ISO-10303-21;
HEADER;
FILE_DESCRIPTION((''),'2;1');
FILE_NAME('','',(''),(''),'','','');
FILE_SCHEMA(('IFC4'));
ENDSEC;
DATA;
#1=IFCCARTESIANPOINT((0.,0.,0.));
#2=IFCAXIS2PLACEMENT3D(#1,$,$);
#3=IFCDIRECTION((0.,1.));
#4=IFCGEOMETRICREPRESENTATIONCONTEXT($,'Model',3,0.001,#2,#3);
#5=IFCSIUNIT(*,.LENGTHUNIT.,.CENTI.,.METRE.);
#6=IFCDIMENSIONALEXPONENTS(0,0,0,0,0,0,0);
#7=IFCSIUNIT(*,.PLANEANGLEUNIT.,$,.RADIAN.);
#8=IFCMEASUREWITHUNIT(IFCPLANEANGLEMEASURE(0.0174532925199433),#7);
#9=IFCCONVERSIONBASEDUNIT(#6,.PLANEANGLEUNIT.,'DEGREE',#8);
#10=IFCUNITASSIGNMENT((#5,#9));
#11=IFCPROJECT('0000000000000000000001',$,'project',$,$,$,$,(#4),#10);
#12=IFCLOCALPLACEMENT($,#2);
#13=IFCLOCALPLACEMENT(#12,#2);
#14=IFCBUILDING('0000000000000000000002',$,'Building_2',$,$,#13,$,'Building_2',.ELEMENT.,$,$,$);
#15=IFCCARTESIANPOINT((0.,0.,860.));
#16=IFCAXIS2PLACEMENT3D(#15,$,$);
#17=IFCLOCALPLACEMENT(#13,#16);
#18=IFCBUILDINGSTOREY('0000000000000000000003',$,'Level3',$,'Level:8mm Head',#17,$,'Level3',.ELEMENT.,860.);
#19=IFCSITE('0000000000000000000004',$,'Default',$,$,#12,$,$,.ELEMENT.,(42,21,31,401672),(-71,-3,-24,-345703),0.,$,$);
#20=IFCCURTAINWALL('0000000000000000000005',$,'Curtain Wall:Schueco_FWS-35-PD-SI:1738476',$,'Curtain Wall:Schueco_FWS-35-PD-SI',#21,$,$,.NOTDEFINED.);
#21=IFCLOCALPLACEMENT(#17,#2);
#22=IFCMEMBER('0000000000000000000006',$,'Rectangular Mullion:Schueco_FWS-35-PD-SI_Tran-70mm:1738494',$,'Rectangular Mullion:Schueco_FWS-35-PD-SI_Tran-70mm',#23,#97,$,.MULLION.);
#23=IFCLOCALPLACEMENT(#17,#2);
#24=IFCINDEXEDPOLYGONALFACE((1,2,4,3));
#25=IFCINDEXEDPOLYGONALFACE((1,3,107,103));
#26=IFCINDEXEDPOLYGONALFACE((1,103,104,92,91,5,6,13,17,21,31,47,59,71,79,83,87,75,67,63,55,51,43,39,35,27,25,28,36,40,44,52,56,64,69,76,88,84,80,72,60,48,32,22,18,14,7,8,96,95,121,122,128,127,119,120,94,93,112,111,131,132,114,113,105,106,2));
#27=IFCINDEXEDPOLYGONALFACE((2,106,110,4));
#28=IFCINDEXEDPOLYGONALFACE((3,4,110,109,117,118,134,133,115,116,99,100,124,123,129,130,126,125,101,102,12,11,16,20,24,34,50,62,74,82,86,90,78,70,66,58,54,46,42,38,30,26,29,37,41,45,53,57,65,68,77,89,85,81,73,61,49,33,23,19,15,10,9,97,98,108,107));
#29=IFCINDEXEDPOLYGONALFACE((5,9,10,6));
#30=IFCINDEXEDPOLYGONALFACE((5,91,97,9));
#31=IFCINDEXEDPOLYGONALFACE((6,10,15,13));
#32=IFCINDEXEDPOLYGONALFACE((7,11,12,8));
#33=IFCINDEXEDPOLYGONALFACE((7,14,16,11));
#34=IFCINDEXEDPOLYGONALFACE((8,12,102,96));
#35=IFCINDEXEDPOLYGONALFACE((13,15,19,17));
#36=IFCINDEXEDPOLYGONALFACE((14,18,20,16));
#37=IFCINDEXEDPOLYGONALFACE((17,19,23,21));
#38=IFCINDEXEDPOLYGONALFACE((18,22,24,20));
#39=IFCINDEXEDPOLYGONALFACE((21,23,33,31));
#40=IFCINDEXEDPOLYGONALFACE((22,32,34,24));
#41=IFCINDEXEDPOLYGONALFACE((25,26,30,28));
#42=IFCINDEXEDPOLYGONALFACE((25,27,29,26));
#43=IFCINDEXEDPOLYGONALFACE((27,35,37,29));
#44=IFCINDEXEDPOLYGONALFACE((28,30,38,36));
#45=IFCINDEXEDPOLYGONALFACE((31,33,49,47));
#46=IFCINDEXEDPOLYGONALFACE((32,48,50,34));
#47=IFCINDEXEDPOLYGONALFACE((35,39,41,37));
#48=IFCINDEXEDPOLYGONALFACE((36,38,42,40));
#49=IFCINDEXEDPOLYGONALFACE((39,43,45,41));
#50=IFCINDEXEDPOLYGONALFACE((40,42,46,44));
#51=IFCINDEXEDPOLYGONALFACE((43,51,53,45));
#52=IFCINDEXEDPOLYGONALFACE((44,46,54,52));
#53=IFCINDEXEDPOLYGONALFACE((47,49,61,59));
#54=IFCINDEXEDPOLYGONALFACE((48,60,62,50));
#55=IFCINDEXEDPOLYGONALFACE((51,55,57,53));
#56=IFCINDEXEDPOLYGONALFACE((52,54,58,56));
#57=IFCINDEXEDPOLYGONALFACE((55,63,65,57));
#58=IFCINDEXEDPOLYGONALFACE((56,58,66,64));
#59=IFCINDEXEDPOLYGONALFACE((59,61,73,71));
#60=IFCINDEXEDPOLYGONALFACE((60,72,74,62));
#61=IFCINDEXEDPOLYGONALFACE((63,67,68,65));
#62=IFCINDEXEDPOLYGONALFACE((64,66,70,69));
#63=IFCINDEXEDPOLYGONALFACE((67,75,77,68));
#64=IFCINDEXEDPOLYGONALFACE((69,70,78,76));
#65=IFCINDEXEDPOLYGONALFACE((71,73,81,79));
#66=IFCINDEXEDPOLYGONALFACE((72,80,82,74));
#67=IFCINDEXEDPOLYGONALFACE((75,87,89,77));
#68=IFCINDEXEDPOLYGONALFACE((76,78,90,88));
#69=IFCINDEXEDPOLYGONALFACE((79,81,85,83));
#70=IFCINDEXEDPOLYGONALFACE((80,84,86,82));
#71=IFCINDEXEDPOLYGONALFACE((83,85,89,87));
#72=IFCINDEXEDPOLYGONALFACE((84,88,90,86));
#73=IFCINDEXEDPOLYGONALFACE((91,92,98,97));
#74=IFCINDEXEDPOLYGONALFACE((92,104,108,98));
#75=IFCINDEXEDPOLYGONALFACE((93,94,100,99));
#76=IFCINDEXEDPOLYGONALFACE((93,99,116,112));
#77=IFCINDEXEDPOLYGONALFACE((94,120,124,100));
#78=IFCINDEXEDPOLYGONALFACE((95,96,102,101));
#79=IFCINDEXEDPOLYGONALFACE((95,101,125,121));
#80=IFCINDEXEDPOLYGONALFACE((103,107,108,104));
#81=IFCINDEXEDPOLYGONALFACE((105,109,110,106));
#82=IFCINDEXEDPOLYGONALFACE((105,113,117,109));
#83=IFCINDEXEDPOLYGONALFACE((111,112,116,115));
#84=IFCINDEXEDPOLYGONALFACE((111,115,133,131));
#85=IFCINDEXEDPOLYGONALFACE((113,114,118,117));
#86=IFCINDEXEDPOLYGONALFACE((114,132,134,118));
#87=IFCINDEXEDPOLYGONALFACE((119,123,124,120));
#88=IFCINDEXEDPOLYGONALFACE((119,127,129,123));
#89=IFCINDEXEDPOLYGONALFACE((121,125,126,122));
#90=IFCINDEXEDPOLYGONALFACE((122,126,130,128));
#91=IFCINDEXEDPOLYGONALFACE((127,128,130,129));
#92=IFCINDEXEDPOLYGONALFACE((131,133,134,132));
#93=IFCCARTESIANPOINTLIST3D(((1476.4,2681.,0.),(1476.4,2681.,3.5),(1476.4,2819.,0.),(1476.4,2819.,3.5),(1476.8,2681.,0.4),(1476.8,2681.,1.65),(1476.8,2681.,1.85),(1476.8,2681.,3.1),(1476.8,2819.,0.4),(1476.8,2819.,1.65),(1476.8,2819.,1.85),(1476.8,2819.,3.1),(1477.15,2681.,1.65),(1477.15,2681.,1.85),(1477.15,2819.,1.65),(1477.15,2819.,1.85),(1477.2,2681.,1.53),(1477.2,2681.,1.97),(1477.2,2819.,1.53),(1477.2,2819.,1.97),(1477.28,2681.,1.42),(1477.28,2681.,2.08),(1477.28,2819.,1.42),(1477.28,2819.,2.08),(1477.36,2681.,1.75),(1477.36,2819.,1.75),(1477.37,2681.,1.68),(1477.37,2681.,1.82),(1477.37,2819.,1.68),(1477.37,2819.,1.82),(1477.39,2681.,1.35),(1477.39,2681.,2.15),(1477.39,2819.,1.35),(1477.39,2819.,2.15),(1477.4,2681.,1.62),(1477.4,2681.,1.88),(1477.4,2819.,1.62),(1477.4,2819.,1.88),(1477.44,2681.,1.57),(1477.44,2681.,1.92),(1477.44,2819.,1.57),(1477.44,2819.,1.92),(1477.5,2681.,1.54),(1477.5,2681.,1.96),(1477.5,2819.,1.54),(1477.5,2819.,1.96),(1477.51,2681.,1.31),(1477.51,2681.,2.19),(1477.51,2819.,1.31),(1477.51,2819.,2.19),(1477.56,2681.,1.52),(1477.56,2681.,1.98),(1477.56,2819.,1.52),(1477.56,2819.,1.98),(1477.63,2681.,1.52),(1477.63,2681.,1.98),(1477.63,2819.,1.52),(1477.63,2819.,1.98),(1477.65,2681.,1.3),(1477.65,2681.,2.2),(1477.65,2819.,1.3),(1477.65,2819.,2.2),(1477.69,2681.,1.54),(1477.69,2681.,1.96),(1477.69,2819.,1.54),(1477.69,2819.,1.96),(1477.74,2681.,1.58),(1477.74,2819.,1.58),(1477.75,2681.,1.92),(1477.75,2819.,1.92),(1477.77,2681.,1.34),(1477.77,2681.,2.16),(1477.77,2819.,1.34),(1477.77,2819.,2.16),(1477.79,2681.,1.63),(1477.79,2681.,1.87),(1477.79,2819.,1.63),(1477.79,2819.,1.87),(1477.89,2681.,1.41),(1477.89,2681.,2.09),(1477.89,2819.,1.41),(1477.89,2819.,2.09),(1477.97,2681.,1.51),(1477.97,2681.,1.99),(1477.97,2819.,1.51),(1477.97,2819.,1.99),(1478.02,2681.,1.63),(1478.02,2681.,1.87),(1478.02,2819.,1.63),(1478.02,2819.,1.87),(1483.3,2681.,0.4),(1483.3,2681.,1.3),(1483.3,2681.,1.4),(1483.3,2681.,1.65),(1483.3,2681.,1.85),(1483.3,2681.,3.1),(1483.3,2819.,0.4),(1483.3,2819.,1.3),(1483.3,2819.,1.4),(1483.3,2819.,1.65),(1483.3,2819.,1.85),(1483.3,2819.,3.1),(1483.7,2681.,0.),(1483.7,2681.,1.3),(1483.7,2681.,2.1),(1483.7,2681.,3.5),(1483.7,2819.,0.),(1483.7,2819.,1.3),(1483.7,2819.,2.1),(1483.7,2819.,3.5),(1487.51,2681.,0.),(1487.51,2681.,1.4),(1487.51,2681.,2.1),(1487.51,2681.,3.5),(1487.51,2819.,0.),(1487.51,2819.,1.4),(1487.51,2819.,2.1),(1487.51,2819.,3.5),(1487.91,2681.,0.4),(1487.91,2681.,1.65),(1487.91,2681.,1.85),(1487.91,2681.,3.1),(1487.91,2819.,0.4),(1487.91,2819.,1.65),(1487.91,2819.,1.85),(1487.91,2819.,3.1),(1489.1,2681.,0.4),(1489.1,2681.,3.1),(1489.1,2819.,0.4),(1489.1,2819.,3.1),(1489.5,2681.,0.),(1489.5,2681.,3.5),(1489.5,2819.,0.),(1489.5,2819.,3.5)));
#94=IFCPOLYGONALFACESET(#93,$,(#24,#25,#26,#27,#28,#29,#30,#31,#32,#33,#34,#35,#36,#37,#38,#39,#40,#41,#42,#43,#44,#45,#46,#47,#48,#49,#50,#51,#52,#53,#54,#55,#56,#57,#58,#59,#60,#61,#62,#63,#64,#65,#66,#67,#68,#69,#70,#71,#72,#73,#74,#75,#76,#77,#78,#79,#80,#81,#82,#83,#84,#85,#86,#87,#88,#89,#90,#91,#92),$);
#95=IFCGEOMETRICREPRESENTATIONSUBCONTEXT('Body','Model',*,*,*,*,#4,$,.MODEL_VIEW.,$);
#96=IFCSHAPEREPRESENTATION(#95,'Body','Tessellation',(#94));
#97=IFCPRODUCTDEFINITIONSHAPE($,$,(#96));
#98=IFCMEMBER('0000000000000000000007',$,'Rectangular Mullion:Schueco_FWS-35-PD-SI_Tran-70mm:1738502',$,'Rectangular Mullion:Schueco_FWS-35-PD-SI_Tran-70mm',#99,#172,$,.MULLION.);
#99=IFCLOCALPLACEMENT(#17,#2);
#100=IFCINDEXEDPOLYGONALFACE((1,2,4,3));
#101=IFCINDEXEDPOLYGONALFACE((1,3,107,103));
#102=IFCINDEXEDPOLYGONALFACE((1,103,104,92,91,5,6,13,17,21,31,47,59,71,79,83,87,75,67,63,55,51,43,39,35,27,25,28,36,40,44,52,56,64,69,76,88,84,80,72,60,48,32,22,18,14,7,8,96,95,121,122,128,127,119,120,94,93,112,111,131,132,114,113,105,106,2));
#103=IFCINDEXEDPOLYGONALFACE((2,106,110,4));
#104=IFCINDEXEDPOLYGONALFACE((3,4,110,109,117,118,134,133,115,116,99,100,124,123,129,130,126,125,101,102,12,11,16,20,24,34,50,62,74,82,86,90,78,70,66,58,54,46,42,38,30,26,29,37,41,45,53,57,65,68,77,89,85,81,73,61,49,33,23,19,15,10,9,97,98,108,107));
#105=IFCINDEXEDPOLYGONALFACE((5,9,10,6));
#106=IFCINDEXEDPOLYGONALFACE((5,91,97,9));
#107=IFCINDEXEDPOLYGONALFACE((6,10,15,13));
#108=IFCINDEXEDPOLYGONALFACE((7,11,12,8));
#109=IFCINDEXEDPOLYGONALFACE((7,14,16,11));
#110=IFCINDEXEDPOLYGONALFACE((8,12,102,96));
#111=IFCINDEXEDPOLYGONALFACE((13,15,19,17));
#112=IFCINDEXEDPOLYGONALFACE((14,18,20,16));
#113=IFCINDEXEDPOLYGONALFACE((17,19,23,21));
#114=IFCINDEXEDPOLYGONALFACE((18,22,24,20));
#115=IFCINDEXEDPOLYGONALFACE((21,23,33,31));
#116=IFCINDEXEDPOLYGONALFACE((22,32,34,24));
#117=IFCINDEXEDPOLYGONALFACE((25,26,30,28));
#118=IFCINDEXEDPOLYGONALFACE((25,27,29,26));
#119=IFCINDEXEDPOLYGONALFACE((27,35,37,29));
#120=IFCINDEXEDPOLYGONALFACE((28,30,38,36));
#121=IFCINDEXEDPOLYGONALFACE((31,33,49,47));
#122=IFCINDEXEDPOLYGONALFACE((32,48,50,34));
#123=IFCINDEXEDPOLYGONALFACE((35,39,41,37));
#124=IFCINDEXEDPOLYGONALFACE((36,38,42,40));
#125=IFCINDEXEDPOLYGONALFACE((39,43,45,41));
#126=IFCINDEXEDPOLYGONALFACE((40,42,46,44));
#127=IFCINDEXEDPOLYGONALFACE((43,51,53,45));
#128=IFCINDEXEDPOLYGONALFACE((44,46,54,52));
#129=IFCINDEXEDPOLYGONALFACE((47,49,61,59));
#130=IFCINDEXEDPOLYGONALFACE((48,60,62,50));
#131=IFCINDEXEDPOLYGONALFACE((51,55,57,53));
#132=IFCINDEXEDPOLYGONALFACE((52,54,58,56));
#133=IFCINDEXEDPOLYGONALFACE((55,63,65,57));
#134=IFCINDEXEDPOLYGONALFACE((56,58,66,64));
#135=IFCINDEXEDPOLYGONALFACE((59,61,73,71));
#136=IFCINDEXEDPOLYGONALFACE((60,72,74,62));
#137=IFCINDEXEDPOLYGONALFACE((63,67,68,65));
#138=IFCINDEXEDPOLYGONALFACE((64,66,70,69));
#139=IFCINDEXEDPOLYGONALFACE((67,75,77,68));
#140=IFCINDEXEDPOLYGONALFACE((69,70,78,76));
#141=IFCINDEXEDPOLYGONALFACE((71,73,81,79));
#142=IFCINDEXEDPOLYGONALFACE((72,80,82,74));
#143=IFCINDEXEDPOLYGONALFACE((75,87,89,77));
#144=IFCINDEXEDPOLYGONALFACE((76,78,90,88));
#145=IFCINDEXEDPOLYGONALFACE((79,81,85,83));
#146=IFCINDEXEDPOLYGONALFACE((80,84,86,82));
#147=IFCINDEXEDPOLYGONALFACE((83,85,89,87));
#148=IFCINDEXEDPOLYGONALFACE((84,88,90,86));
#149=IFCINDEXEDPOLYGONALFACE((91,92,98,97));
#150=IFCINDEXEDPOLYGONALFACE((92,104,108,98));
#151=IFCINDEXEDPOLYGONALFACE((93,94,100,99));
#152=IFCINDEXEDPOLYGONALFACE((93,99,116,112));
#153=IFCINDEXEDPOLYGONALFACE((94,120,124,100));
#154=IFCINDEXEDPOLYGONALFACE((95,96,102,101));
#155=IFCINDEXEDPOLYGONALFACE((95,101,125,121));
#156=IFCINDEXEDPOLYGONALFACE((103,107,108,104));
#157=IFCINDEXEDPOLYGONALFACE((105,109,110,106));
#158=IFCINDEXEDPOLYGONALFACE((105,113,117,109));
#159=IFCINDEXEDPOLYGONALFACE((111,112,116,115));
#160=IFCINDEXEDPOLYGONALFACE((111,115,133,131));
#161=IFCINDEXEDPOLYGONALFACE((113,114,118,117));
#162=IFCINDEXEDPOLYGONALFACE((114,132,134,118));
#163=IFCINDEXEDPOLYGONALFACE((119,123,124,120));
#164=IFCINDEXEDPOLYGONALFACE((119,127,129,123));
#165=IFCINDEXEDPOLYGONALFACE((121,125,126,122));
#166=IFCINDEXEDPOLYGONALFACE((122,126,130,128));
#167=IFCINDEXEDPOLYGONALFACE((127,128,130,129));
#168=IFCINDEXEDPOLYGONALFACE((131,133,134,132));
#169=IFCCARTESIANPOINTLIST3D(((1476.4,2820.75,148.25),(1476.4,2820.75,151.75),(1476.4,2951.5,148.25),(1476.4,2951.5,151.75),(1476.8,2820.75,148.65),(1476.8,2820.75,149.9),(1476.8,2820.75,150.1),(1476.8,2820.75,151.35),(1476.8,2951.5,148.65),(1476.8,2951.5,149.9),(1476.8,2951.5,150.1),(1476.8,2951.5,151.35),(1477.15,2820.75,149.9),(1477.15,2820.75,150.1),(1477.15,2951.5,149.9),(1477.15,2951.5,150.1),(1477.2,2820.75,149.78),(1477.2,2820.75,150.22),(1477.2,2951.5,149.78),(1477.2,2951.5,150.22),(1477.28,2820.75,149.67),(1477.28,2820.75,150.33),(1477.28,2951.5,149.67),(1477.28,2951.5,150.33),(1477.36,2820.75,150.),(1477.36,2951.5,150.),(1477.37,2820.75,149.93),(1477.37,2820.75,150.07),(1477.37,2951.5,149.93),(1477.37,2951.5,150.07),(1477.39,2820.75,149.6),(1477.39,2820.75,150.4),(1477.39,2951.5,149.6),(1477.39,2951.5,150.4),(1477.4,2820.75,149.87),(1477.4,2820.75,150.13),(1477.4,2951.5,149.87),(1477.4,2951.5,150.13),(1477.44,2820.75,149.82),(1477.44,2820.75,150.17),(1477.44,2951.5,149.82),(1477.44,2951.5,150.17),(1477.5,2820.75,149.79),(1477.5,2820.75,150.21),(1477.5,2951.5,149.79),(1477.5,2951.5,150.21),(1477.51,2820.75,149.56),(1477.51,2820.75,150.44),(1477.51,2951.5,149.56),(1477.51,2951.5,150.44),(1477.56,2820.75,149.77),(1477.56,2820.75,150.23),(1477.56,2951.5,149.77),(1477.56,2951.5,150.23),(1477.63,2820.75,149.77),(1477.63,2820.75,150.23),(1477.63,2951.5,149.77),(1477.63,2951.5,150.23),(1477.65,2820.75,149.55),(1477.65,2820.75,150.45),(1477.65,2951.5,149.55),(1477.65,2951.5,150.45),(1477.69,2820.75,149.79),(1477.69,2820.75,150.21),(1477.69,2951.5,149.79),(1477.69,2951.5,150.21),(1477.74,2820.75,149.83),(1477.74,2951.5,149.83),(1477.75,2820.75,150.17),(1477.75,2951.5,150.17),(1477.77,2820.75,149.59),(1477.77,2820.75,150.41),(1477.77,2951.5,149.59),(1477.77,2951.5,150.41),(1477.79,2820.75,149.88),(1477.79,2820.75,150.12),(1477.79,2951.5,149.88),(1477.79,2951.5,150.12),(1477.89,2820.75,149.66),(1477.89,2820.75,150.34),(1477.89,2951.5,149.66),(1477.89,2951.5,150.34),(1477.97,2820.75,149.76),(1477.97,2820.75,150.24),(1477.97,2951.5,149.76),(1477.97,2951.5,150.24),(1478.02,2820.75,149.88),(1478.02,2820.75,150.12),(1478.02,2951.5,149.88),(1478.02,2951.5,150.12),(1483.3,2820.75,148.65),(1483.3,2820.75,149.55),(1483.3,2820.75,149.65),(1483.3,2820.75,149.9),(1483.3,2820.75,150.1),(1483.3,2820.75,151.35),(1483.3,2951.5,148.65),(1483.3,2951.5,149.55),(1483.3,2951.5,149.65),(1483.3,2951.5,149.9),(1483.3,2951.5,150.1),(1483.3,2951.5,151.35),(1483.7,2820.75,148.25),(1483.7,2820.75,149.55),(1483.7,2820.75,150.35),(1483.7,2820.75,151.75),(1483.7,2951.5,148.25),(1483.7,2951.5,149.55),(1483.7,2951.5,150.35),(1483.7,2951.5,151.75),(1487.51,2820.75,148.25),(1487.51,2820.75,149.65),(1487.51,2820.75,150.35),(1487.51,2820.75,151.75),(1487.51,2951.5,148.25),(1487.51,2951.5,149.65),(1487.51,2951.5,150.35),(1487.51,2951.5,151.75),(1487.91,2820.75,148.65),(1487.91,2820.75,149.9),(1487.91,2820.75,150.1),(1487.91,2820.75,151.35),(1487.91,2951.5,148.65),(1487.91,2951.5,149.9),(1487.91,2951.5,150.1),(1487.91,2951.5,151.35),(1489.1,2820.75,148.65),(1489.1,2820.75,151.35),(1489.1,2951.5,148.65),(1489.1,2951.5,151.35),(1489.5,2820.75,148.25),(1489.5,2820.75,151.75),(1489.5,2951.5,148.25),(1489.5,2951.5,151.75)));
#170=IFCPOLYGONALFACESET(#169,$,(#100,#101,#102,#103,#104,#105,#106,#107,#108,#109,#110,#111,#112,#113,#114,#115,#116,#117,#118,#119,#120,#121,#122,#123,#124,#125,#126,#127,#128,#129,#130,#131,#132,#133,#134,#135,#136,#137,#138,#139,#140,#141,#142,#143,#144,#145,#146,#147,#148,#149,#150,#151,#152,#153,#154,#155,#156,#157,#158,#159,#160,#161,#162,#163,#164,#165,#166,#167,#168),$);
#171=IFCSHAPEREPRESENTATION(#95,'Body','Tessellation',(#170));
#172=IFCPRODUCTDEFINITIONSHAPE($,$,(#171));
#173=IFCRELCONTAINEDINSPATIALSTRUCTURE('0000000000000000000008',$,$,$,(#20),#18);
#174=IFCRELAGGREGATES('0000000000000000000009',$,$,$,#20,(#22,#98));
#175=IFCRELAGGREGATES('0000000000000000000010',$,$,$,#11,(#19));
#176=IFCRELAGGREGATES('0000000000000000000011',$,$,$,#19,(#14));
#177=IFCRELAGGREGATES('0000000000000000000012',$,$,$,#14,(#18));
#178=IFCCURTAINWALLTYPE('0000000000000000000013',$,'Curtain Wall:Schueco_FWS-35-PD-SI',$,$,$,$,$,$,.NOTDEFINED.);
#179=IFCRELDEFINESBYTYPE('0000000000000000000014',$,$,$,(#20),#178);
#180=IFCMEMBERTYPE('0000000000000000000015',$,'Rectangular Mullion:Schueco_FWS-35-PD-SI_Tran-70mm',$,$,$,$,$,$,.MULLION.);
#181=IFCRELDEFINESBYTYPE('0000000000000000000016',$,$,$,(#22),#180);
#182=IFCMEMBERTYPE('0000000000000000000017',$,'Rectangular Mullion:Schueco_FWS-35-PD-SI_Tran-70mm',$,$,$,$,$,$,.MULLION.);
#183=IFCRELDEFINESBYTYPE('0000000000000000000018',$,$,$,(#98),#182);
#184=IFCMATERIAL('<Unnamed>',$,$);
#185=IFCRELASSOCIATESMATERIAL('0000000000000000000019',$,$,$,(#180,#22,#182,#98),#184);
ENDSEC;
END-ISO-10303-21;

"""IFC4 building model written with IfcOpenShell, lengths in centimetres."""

from ifc_helpers import new_model, entity, si_unit, converted_unit, direction, frame, origin, place, context, subcontext, project, spatial, line, arc, indexed_curve, outline, extrude, source, transform, mapped, material, type_object, type_shapes, element, aggregate, save


model = new_model("IFC4")

# Units and contexts
model_context = context("Model", 3, precision=0.001, world=origin(), true_north=direction((0.0, 1.0)))
body_context = subcontext(model_context, "Body", "Model", "MODEL_VIEW")
ifc_project = project(units=[si_unit("LENGTHUNIT", "METRE", prefix="CENTI"), converted_unit("PLANEANGLEUNIT", "DEGREE", entity("IfcPlaneAngleMeasure", 0.0174532925199433), si_unit("PLANEANGLEUNIT", "RADIAN"), dimensions=[0, 0, 0, 0, 0, 0, 0])], contexts=[model_context])

# Site, building, storey
site_placement = place(None, origin())
site = spatial("IfcSite", under=ifc_project, at=site_placement, Name="Default", CompositionType="ELEMENT", RefLatitude=(42, 21, 31, 401672), RefLongitude=(-71, -3, -24, -345703), RefElevation=0.0)
building_placement = place(site_placement, origin())
building = spatial("IfcBuilding", under=site, at=building_placement, Name="Building_2", LongName="Building_2", CompositionType="ELEMENT")
storey_placement = place(building_placement, frame((0.0, 0.0, 860.0)))
storey = spatial("IfcBuildingStorey", under=building, at=storey_placement, Name="Level3", ObjectType="Level:8mm Head", LongName="Level3", CompositionType="ELEMENT", Elevation=860.0)

# Curtain wall, members
curtain_wall_type = type_object("IfcCurtainWallType", Name="Curtain Wall:Schueco_FWS-35-PD-SI", PredefinedType="NOTDEFINED")
curtain_wall_placement = place(storey_placement, frame((0.0, 0.0, -860.0)))
curtain_wall = element("IfcCurtainWall", 1, at=curtain_wall_placement, inside=storey, type_object=curtain_wall_type, Name="Curtain Wall:Schueco_FWS-35-PD-SI:1738476", ObjectType="Curtain Wall:Schueco_FWS-35-PD-SI", PredefinedType="NOTDEFINED")
ifc_material_1 = material(Name="<Unnamed>")
member_type_1 = type_object("IfcMemberType", Name="Rectangular Mullion:Schueco_FWS-35-PD-SI_Tran-70mm", PredefinedType="MULLION", material=ifc_material_1)
shared_shape_1 = source(origin(), body_context, "Body", "SweptSolid", [
    extrude(outline(indexed_curve([(-6.52, -1.78), (0.78, -1.78), (0.78, -0.38), (4.59, -0.38), (4.59, -1.78), (6.58, -1.78), (6.58, 1.72), (4.59, 1.72), (4.59, 0.32), (0.38, 0.32), (0.38, 0.07), (4.99, 0.07), (4.99, 1.32), (6.18, 1.32), (6.18, -1.38), (4.99, -1.38), (4.99, -0.13), (0.38, -0.13), (0.38, -1.38), (-6.12, -1.38), (-6.12, -0.13), (-5.77, -0.13), (-5.34, -0.48), (-4.9, -0.15), (-5.14, -0.15), (-5.56, -0.03), (-5.14, 0.09), (-4.9, 0.09), (-5.34, 0.42), (-5.77, 0.07), (-6.12, 0.07), (-6.12, 1.32), (0.38, 1.32), (0.38, 0.42), (0.78, 0.42), (0.78, 1.72), (-6.52, 1.72)], segments=[line(1, 2, 3, 4, 5, 6, 7, 8, 9, 10, 11, 12, 13, 14, 15, 16, 17, 18, 19, 20, 21, 22), arc(22, 23, 24), line(24, 25), arc(25, 26, 27), line(27, 28), arc(28, 29, 30), line(30, 31, 32, 33, 34, 35, 36, 37, 1)], self_intersect=False)), frame((-1.72, 4.58, -138.0), z_axis=(0.0, 0.0, 1.0), x_axis=(0.0, -1.0, 0.0)), (0.0, 0.0, 1.0), 138.0),
])
type_shapes(member_type_1, [shared_shape_1])
member_1_placement = place(curtain_wall_placement, frame((1487.5, 2819.0, 860.0), z_axis=(0.0, 1.0, 0.0), x_axis=(0.0, 0.0, -1.0)))
member_1 = element("IfcMember", 2, at=member_1_placement, type_object=member_type_1, material=ifc_material_1, Name="Rectangular Mullion:Schueco_FWS-35-PD-SI_Tran-70mm:1738494", ObjectType="Rectangular Mullion:Schueco_FWS-35-PD-SI_Tran-70mm", PredefinedType="MULLION", context=body_context, shape_type="MappedRepresentation", body=[
    mapped(shared_shape_1, transform((0.0, 0.0, 0.0), scale=1.0)),
])
member_type_2 = type_object("IfcMemberType", Name="Rectangular Mullion:Schueco_FWS-35-PD-SI_Tran-70mm", PredefinedType="MULLION", material=ifc_material_1)
shared_shape_2 = source(origin(), body_context, "Body", "SweptSolid", [
    extrude(outline(indexed_curve([(-1.78, -6.52), (1.72, -6.52), (1.72, 0.78), (0.42, 0.78), (0.42, 0.38), (1.32, 0.38), (1.32, -6.12), (0.07, -6.12), (0.07, -5.77), (0.42, -5.34), (0.09, -4.9), (0.09, -5.14), (-0.03, -5.56), (-0.15, -5.14), (-0.15, -4.9), (-0.48, -5.34), (-0.13, -5.77), (-0.13, -6.12), (-1.38, -6.12), (-1.38, 0.38), (-0.13, 0.38), (-0.13, 4.99), (-1.38, 4.99), (-1.38, 6.18), (1.32, 6.18), (1.32, 4.99), (0.07, 4.99), (0.07, 0.38), (0.32, 0.38), (0.32, 4.59), (1.72, 4.59), (1.72, 6.58), (-1.78, 6.58), (-1.78, 4.59), (-0.38, 4.59), (-0.38, 0.78), (-1.78, 0.78)], segments=[line(1, 2, 3, 4, 5, 6, 7, 8, 9), arc(9, 10, 11), line(11, 12), arc(12, 13, 14), line(14, 15), arc(15, 16, 17), line(17, 18, 19, 20, 21, 22, 23, 24, 25, 26, 27, 28, 29, 30, 31, 32, 33, 34, 35, 36, 37, 1)], self_intersect=False)), frame((-0.03, 4.58, -130.75), z_axis=(0.0, 0.0, 1.0), x_axis=(-1.0, 0.0, 0.0)), (0.0, 0.0, 1.0), 130.75),
])
type_shapes(member_type_2, [shared_shape_2])
member_2_placement = place(curtain_wall_placement, frame((1487.5, 2820.75, 1010.0), z_axis=(0.0, -1.0, 0.0), x_axis=(0.0, 0.0, 1.0)))
member_2 = element("IfcMember", 3, at=member_2_placement, type_object=member_type_2, material=ifc_material_1, Name="Rectangular Mullion:Schueco_FWS-35-PD-SI_Tran-70mm:1738502", ObjectType="Rectangular Mullion:Schueco_FWS-35-PD-SI_Tran-70mm", PredefinedType="MULLION", context=body_context, shape_type="MappedRepresentation", body=[
    mapped(shared_shape_2, transform((0.0, 0.0, 0.0), scale=1.0)),
])
aggregate(curtain_wall, [member_1, member_2])

save(model, "model.ifc")
